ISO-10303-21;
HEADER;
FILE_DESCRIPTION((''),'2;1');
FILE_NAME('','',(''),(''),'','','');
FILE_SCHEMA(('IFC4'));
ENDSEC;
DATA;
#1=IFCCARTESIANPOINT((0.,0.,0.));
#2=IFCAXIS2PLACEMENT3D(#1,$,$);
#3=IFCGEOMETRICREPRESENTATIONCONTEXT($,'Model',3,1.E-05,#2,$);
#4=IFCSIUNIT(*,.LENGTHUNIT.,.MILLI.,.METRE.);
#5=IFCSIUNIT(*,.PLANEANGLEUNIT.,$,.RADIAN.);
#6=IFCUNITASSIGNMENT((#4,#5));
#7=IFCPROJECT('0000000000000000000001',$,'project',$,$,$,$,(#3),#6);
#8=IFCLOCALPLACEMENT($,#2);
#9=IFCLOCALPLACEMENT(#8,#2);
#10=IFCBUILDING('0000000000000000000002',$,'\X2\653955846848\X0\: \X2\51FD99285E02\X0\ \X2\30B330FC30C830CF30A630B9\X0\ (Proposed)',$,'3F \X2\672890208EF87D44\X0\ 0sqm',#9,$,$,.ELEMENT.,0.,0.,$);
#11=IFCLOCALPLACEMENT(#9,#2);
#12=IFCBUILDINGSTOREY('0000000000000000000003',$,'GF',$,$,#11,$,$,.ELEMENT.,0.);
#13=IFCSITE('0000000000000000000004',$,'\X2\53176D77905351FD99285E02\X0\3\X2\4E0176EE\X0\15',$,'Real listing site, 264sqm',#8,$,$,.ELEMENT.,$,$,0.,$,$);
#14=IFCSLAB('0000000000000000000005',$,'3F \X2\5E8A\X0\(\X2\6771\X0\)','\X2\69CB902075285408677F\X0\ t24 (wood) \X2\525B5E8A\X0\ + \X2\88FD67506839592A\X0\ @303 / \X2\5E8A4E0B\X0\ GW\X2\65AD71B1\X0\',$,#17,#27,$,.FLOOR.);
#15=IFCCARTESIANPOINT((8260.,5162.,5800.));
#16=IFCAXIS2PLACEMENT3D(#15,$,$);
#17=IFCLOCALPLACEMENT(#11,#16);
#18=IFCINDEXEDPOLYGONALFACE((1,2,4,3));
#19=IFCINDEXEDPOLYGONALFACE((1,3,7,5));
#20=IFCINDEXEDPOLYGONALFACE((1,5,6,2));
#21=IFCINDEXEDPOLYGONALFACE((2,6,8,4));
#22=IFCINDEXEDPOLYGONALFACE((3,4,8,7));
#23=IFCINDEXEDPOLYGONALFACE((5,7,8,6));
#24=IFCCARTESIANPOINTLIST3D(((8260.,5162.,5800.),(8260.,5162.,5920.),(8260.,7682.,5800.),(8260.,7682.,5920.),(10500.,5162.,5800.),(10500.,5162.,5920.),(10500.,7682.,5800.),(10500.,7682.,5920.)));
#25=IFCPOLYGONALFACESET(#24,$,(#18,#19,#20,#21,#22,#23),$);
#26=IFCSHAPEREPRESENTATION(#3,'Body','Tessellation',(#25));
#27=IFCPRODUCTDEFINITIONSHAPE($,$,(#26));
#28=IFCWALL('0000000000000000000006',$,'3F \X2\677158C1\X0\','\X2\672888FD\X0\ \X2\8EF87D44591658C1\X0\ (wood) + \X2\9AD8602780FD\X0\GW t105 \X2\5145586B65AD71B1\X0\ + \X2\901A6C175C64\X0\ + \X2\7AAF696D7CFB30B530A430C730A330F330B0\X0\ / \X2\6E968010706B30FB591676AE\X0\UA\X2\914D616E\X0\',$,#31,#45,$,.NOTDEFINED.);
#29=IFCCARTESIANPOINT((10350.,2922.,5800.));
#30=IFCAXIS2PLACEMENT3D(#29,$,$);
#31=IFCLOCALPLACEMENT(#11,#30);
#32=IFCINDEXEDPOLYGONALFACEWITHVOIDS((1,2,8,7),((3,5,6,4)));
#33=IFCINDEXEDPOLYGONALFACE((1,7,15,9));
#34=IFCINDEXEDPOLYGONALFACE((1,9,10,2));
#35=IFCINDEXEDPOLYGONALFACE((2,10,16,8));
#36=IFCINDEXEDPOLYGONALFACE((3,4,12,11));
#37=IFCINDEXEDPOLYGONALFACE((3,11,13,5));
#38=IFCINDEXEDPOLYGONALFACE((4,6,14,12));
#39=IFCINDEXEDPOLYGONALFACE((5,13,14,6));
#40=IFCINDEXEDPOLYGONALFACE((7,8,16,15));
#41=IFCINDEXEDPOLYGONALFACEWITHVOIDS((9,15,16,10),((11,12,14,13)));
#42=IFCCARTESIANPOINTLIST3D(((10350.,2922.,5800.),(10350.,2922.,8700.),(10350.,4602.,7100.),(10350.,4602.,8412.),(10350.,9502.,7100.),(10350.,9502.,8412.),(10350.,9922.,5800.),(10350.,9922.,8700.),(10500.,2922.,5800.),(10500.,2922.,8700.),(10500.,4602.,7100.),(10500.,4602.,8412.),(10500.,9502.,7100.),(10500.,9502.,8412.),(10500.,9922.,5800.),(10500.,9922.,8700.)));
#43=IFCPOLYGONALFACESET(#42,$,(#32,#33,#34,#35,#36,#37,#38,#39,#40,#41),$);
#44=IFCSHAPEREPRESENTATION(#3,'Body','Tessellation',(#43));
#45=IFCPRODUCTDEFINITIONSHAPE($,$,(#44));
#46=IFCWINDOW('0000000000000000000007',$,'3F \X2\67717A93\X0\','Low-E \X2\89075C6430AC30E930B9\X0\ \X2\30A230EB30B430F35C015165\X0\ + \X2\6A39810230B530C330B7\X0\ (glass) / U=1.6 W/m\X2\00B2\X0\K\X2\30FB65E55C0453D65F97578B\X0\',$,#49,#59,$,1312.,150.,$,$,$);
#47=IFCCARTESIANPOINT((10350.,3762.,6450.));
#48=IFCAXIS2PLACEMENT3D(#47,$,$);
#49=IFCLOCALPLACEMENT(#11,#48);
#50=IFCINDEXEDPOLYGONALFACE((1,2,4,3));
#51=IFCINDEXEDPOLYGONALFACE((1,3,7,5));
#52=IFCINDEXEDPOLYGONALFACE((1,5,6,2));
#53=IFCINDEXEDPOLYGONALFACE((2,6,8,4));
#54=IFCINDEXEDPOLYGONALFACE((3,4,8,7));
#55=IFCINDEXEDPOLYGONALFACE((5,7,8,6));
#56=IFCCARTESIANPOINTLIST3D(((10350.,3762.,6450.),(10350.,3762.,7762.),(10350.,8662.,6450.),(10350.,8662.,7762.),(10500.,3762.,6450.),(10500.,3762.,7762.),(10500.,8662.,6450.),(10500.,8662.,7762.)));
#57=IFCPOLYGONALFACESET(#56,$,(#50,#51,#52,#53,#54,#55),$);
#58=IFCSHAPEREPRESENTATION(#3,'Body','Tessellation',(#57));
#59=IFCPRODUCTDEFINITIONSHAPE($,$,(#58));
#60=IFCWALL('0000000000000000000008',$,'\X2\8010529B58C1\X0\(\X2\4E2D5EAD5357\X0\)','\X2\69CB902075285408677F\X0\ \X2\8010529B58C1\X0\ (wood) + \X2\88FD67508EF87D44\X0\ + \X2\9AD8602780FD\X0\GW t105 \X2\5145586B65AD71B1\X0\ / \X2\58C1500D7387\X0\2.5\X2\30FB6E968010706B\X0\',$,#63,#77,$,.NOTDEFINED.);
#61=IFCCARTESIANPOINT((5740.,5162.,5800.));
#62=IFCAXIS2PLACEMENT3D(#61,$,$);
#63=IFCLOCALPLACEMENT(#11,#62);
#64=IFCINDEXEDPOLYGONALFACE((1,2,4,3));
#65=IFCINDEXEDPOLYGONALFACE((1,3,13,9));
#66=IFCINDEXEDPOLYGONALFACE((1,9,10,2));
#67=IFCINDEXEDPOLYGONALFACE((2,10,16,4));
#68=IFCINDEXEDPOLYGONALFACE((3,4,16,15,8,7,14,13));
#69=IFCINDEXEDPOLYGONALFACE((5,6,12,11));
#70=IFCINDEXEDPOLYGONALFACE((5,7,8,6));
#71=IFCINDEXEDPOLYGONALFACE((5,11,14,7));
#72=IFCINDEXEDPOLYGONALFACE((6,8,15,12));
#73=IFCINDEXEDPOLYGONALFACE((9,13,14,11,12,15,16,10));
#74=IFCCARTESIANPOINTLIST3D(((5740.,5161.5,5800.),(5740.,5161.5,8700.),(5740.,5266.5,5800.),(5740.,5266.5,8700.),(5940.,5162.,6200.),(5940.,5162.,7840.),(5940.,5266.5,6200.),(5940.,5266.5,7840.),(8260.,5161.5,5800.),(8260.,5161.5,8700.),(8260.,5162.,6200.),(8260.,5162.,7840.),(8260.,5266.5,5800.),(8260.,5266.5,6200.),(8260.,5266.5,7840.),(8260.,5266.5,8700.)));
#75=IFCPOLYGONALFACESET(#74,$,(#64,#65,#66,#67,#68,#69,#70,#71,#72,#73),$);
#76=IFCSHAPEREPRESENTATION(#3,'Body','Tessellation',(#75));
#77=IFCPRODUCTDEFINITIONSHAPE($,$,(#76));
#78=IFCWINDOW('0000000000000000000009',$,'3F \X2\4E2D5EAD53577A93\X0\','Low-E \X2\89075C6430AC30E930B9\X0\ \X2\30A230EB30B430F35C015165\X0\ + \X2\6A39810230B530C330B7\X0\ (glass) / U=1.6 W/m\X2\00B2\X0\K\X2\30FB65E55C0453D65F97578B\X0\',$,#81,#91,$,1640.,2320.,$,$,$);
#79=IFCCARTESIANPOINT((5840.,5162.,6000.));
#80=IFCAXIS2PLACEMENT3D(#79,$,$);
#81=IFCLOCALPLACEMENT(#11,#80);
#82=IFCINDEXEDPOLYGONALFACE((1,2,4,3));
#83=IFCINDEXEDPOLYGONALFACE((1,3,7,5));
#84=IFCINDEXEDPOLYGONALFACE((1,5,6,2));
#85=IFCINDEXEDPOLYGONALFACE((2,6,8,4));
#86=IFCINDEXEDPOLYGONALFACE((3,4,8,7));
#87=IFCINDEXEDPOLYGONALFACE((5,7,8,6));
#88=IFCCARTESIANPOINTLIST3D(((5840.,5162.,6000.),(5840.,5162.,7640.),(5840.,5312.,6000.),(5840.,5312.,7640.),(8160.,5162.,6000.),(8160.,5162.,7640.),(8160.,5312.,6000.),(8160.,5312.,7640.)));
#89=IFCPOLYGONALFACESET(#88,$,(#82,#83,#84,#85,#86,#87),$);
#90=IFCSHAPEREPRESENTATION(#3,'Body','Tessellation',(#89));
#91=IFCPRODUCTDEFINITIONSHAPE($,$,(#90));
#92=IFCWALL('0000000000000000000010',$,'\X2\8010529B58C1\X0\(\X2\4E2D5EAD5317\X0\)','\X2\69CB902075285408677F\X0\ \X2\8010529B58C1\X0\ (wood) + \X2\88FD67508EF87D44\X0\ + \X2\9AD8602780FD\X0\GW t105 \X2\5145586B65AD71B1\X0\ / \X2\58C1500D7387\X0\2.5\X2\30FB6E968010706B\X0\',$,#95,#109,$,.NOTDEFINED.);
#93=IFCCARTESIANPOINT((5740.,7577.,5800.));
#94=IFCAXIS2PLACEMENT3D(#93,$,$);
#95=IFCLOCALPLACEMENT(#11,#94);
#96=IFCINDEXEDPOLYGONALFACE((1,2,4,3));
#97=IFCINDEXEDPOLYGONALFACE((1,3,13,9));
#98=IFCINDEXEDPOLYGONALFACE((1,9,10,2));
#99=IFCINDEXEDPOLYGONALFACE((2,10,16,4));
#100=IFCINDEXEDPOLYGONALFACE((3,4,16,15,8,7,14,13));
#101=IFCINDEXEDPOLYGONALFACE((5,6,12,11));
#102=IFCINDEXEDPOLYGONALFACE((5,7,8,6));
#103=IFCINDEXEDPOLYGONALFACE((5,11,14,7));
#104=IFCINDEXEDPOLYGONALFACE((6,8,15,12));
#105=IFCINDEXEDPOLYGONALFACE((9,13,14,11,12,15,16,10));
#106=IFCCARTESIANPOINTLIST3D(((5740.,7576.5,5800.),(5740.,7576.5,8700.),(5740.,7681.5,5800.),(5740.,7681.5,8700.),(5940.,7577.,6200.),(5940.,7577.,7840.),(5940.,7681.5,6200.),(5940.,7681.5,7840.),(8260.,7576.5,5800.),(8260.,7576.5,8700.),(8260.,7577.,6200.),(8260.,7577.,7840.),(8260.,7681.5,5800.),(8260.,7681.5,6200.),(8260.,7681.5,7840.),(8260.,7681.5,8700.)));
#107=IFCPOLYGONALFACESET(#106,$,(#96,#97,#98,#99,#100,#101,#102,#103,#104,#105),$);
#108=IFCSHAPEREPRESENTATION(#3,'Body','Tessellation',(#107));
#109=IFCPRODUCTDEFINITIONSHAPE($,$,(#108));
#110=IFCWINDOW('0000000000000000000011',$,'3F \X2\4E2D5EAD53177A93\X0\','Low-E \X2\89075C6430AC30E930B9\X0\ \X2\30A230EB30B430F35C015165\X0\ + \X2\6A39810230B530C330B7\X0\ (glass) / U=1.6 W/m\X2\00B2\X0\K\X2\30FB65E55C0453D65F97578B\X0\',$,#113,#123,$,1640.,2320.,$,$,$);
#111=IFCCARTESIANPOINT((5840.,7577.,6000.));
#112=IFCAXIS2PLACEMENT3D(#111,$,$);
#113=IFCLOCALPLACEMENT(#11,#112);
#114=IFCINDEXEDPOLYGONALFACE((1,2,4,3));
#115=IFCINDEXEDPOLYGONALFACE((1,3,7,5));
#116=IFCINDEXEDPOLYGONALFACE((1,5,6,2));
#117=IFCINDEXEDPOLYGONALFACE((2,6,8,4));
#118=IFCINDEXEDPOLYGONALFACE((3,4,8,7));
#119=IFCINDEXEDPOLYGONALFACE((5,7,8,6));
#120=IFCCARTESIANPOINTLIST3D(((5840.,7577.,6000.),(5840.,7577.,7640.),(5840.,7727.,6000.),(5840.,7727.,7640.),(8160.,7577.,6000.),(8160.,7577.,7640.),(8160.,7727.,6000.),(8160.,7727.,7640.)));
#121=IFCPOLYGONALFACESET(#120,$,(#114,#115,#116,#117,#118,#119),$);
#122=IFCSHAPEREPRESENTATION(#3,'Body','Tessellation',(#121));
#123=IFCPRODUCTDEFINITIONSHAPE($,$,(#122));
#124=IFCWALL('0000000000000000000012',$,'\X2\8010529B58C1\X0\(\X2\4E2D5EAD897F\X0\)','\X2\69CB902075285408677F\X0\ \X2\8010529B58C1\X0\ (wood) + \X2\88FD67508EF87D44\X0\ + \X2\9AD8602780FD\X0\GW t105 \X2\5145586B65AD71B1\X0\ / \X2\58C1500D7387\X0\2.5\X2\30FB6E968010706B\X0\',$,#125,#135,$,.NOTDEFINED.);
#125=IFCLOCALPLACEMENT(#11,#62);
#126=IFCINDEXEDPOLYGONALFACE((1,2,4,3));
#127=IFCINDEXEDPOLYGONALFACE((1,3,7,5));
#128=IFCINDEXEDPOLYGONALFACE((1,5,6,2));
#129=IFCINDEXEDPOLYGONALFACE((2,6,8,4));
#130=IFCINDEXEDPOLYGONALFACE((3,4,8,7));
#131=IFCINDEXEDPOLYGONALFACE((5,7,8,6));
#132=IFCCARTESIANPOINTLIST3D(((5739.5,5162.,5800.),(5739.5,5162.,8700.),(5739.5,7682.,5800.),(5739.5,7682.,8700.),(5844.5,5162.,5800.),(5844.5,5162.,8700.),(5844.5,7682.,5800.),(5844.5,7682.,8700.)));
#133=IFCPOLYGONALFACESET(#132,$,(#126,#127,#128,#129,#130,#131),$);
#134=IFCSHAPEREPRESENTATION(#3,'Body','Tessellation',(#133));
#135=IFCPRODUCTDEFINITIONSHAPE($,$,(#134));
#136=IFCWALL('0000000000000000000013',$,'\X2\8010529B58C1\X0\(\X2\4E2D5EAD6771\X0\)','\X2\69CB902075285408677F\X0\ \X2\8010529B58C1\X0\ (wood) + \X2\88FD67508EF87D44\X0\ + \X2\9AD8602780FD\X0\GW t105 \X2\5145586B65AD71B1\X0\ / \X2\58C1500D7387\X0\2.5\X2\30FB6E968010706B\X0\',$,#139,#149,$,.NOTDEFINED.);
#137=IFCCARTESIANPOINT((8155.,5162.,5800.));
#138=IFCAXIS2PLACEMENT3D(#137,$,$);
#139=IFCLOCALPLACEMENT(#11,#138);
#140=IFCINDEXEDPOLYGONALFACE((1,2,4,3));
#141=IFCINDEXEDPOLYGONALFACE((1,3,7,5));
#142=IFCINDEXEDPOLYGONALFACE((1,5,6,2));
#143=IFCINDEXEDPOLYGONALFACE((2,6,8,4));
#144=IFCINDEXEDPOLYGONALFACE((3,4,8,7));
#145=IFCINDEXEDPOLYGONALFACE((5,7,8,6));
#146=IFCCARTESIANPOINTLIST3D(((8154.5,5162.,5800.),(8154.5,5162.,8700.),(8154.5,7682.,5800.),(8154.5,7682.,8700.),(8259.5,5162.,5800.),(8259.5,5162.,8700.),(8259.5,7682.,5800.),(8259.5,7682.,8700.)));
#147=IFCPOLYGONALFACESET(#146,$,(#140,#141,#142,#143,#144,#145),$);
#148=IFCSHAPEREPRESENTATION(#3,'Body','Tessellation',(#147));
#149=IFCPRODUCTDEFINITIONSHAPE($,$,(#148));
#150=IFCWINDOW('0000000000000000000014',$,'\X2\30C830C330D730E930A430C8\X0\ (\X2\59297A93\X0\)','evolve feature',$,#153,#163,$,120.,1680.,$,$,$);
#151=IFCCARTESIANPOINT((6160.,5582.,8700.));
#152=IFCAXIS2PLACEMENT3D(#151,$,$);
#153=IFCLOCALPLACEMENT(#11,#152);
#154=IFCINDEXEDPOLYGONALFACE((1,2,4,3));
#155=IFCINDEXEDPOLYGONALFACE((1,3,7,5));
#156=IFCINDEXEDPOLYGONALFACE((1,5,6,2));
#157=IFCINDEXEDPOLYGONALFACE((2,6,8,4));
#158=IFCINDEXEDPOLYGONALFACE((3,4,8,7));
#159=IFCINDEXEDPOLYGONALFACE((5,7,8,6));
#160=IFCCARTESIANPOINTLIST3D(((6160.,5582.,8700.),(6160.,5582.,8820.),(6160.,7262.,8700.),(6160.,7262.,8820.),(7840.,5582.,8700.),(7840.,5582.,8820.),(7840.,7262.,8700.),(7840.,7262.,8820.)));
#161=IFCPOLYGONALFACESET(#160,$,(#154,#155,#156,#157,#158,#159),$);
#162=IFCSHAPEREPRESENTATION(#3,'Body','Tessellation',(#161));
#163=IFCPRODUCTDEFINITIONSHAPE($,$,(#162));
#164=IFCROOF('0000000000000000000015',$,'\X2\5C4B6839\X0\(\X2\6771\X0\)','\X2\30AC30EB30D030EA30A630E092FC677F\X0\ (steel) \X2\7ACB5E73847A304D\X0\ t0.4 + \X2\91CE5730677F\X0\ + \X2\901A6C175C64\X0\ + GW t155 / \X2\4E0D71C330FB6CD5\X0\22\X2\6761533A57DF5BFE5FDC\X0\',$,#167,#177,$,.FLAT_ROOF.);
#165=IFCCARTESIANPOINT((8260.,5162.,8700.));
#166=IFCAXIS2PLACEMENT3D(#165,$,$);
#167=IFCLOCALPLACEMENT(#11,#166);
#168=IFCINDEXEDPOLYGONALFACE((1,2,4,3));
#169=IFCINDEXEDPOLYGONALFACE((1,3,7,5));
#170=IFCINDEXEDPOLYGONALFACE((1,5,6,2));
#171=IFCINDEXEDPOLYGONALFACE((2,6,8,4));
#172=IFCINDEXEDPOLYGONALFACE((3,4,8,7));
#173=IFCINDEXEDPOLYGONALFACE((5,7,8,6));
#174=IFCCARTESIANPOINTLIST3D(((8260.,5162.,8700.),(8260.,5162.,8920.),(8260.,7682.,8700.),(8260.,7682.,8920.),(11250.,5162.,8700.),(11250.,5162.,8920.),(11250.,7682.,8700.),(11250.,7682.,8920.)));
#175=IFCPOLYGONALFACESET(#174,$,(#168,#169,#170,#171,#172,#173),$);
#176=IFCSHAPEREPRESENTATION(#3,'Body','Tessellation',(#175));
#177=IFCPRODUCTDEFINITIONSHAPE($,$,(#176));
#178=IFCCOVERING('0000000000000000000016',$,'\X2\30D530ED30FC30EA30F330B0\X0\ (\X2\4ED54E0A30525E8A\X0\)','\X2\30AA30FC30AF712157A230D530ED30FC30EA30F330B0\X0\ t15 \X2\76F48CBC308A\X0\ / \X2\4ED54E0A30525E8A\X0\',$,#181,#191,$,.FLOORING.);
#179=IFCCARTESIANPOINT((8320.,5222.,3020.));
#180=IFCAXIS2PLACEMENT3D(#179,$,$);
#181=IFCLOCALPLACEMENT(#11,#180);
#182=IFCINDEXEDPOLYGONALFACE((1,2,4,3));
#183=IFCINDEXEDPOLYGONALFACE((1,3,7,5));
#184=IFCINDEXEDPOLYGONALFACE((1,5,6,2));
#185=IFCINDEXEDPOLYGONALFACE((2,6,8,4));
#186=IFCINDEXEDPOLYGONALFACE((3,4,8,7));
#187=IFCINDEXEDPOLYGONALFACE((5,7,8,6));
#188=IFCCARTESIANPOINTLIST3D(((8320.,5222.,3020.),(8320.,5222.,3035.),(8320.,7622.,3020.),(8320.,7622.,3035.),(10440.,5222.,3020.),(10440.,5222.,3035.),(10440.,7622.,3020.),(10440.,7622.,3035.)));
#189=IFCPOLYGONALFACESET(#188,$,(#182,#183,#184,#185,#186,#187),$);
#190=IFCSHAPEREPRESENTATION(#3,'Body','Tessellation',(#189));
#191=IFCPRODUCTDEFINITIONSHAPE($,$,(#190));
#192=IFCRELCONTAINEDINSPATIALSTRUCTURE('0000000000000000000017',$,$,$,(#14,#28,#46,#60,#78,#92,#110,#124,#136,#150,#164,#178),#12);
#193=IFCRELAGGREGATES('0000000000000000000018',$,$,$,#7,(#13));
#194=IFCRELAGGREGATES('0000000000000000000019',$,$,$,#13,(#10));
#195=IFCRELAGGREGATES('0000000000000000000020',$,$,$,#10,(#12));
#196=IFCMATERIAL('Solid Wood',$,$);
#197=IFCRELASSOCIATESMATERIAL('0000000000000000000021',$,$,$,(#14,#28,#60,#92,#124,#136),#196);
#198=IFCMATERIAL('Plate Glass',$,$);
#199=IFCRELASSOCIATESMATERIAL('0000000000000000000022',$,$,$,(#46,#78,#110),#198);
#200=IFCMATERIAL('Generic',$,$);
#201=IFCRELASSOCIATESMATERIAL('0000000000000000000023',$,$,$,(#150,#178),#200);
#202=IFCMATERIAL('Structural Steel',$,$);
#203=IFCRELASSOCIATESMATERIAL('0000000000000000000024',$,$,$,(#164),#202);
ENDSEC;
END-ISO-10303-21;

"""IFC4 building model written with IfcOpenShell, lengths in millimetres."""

from ifc_helpers import new_model, si_unit, frame, frame_2d, origin, place, context, project, spatial, rectangle, extrude, material, element, fill, save


model = new_model("IFC4")

# Units and contexts
model_context = context("Model", 3, precision=1e-05, world=origin())
ifc_project = project(units=[si_unit("LENGTHUNIT", "METRE", prefix="MILLI"), si_unit("PLANEANGLEUNIT", "RADIAN")], contexts=[model_context])

# Site, building, storey
site_placement = place(None, origin())
site = spatial("IfcSite", under=ifc_project, at=site_placement, Name="北海道函館市3丁目15", ObjectType="Real listing site, 264sqm", CompositionType="ELEMENT", RefElevation=0.0)
building_placement = place(site_placement, origin())
building = spatial("IfcBuilding", under=site, at=building_placement, Name="改善案: 函館市 コートハウス (Proposed)", ObjectType="3F 木造軸組 0sqm", CompositionType="ELEMENT", ElevationOfRefHeight=0.0, ElevationOfTerrain=0.0)
storey_placement = place(building_placement, origin())
storey = spatial("IfcBuildingStorey", under=building, at=storey_placement, Name="GF", CompositionType="ELEMENT", Elevation=0.0)

# Slab
ifc_material_1 = material(Name="Solid Wood")
slab_placement = place(storey_placement, frame((8260.0, 5162.0, 5800.0)))
element("IfcSlab", 1, at=slab_placement, inside=storey, material=ifc_material_1, Name="3F 床(東)", Description="構造用合板 t24 (wood) 剛床 + 製材根太 @303 / 床下 GW断熱", PredefinedType="FLOOR", context=model_context, shape_type="SweptSolid", body=[
    extrude(rectangle(XDim=2240.0, YDim=2520.0, at=frame_2d((1120.0, 1260.0))), frame((8260.0, 5162.0, 5800.0)), (0.0, 0.0, 1.0), 120.0),
])

# Walls, openings, windows
wall_1_placement = place(storey_placement, frame((10350.0, 2922.0, 5800.0)))
wall_1 = element("IfcWall", 2, at=wall_1_placement, inside=storey, material=ifc_material_1, Name="3F 東壁", Description="木製 軸組外壁 (wood) + 高性能GW t105 充填断熱 + 通気層 + 窯業系サイディング / 準耐火・外皮UA配慮", PredefinedType="NOTDEFINED", context=model_context, shape_type="SweptSolid", body=[
    extrude(rectangle(XDim=150.0, YDim=7000.0, at=frame_2d((75.0, 3500.0))), frame((10350.0, 2922.0, 5800.0)), (0.0, 0.0, 1.0), 2900.0),
])
opening_1_placement = place(storey_placement, frame((10350.0, 3762.0, 6450.0)))
opening_1 = element("IfcOpeningElement", 3, at=opening_1_placement, cuts=wall_1, PredefinedType="NOTDEFINED", context=model_context, shape_type="SweptSolid", body=[
    extrude(rectangle(XDim=150.0, YDim=4900.0, at=frame_2d((75.0, 2450.0))), frame((10350.0, 3762.0, 6450.0)), (0.0, 0.0, 1.0), 1312.0),
])
ifc_material_2 = material(Name="Plate Glass")
window_1_placement = place(storey_placement, frame((10350.0, 3762.0, 6450.0)))
window_1 = element("IfcWindow", 4, at=window_1_placement, inside=storey, material=ifc_material_2, Name="3F 東窓", Description="Low-E 複層ガラス アルゴン封入 + 樹脂サッシ (glass) / U=1.6 W/m²K・日射取得型", OverallHeight=1312.0, OverallWidth=150.0, context=model_context, shape_type="SweptSolid", body=[
    extrude(rectangle(XDim=150.0, YDim=4900.0, at=frame_2d((75.0, 2450.0))), frame((10350.0, 3762.0, 6450.0)), (0.0, 0.0, 1.0), 1312.0),
])
fill(opening_1, window_1)
wall_2_placement = place(storey_placement, frame((5740.0, 5162.0, 5800.0)))
wall_2 = element("IfcWall", 5, at=wall_2_placement, inside=storey, material=ifc_material_1, Name="耐力壁(中庭南)", Description="構造用合板 耐力壁 (wood) + 製材軸組 + 高性能GW t105 充填断熱 / 壁倍率2.5・準耐火", PredefinedType="NOTDEFINED", context=model_context, shape_type="SweptSolid", body=[
    extrude(rectangle(XDim=2520.0, YDim=105.0, at=frame_2d((1260.0, 52.0))), frame((5740.0, 5162.0, 5800.0)), (0.0, 0.0, 1.0), 2900.0),
])
opening_2_placement = place(storey_placement, frame((5840.0, 5162.0, 6000.0)))
opening_2 = element("IfcOpeningElement", 6, at=opening_2_placement, cuts=wall_2, PredefinedType="NOTDEFINED", context=model_context, shape_type="SweptSolid", body=[
    extrude(rectangle(XDim=2320.0, YDim=150.0, at=frame_2d((1160.0, 75.0))), frame((5840.0, 5162.0, 6000.0)), (0.0, 0.0, 1.0), 1640.0),
])
window_2_placement = place(storey_placement, frame((5840.0, 5162.0, 6000.0)))
window_2 = element("IfcWindow", 7, at=window_2_placement, inside=storey, material=ifc_material_2, Name="3F 中庭南窓", Description="Low-E 複層ガラス アルゴン封入 + 樹脂サッシ (glass) / U=1.6 W/m²K・日射取得型", OverallHeight=1640.0, OverallWidth=2320.0, context=model_context, shape_type="SweptSolid", body=[
    extrude(rectangle(XDim=2320.0, YDim=150.0, at=frame_2d((1160.0, 75.0))), frame((5840.0, 5162.0, 6000.0)), (0.0, 0.0, 1.0), 1640.0),
])
fill(opening_2, window_2)
wall_3_placement = place(storey_placement, frame((5740.0, 7577.0, 5800.0)))
wall_3 = element("IfcWall", 8, at=wall_3_placement, inside=storey, material=ifc_material_1, Name="耐力壁(中庭北)", Description="構造用合板 耐力壁 (wood) + 製材軸組 + 高性能GW t105 充填断熱 / 壁倍率2.5・準耐火", PredefinedType="NOTDEFINED", context=model_context, shape_type="SweptSolid", body=[
    extrude(rectangle(XDim=2520.0, YDim=105.0, at=frame_2d((1260.0, 52.0))), frame((5740.0, 7577.0, 5800.0)), (0.0, 0.0, 1.0), 2900.0),
])
opening_3_placement = place(storey_placement, frame((5840.0, 7577.0, 6000.0)))
opening_3 = element("IfcOpeningElement", 9, at=opening_3_placement, cuts=wall_3, PredefinedType="NOTDEFINED", context=model_context, shape_type="SweptSolid", body=[
    extrude(rectangle(XDim=2320.0, YDim=150.0, at=frame_2d((1160.0, 75.0))), frame((5840.0, 7577.0, 6000.0)), (0.0, 0.0, 1.0), 1640.0),
])
window_3_placement = place(storey_placement, frame((5840.0, 7577.0, 6000.0)))
window_3 = element("IfcWindow", 10, at=window_3_placement, inside=storey, material=ifc_material_2, Name="3F 中庭北窓", Description="Low-E 複層ガラス アルゴン封入 + 樹脂サッシ (glass) / U=1.6 W/m²K・日射取得型", OverallHeight=1640.0, OverallWidth=2320.0, context=model_context, shape_type="SweptSolid", body=[
    extrude(rectangle(XDim=2320.0, YDim=150.0, at=frame_2d((1160.0, 75.0))), frame((5840.0, 7577.0, 6000.0)), (0.0, 0.0, 1.0), 1640.0),
])
fill(opening_3, window_3)

# Walls
wall_4_placement = place(storey_placement, frame((5740.0, 5162.0, 5800.0)))
element("IfcWall", 11, at=wall_4_placement, inside=storey, material=ifc_material_1, Name="耐力壁(中庭西)", Description="構造用合板 耐力壁 (wood) + 製材軸組 + 高性能GW t105 充填断熱 / 壁倍率2.5・準耐火", PredefinedType="NOTDEFINED", context=model_context, shape_type="SweptSolid", body=[
    extrude(rectangle(XDim=105.0, YDim=2520.0, at=frame_2d((52.0, 1260.0))), frame((5740.0, 5162.0, 5800.0)), (0.0, 0.0, 1.0), 2900.0),
])
wall_5_placement = place(storey_placement, frame((8155.0, 5162.0, 5800.0)))
element("IfcWall", 12, at=wall_5_placement, inside=storey, material=ifc_material_1, Name="耐力壁(中庭東)", Description="構造用合板 耐力壁 (wood) + 製材軸組 + 高性能GW t105 充填断熱 / 壁倍率2.5・準耐火", PredefinedType="NOTDEFINED", context=model_context, shape_type="SweptSolid", body=[
    extrude(rectangle(XDim=105.0, YDim=2520.0, at=frame_2d((52.0, 1260.0))), frame((8155.0, 5162.0, 5800.0)), (0.0, 0.0, 1.0), 2900.0),
])

# Window
ifc_material_3 = material(Name="Generic")
window_4_placement = place(storey_placement, frame((6160.0, 5582.0, 8700.0)))
element("IfcWindow", 13, at=window_4_placement, inside=storey, material=ifc_material_3, Name="トップライト (天窓)", Description="evolve feature", OverallHeight=120.0, OverallWidth=1680.0, context=model_context, shape_type="SweptSolid", body=[
    extrude(rectangle(XDim=1680.0, YDim=1680.0, at=frame_2d((840.0, 840.0))), frame((6160.0, 5582.0, 8700.0)), (0.0, 0.0, 1.0), 120.0),
])

# Roof
ifc_material_4 = material(Name="Structural Steel")
for number, where, name in (
    (14, (8260.0, 5162.0, 8700.0), "屋根(東)"),
):
    element("IfcRoof", number, at=place(storey_placement, frame(where)), inside=storey, material=ifc_material_4, Name=name, Description="ガルバリウム鋼板 (steel) 立平葺き t0.4 + 野地板 + 通気層 + GW t155 / 不燃・法22条区域対応", PredefinedType="FLAT_ROOF", context=model_context, shape_type="SweptSolid", body=[
        extrude(rectangle(XDim=2990.0, YDim=2520.0, at=frame_2d((1495.0, 1260.0))), frame((8260.0, 5162.0, 8700.0)), (0.0, 0.0, 1.0), 220.0),
    ])

# Covering
covering_1_placement = place(storey_placement, frame((8320.0, 5222.0, 3020.0)))
element("IfcCovering", 15, at=covering_1_placement, inside=storey, material=ifc_material_3, Name="フローリング (仕上げ床)", Description="オーク無垢フローリング t15 直貼り / 仕上げ床", PredefinedType="FLOORING", context=model_context, shape_type="SweptSolid", body=[
    extrude(rectangle(XDim=2120.0, YDim=2400.0, at=frame_2d((1060.0, 1200.0))), frame((8320.0, 5222.0, 3020.0)), (0.0, 0.0, 1.0), 15.0),
])

save(model, "model.ifc")
